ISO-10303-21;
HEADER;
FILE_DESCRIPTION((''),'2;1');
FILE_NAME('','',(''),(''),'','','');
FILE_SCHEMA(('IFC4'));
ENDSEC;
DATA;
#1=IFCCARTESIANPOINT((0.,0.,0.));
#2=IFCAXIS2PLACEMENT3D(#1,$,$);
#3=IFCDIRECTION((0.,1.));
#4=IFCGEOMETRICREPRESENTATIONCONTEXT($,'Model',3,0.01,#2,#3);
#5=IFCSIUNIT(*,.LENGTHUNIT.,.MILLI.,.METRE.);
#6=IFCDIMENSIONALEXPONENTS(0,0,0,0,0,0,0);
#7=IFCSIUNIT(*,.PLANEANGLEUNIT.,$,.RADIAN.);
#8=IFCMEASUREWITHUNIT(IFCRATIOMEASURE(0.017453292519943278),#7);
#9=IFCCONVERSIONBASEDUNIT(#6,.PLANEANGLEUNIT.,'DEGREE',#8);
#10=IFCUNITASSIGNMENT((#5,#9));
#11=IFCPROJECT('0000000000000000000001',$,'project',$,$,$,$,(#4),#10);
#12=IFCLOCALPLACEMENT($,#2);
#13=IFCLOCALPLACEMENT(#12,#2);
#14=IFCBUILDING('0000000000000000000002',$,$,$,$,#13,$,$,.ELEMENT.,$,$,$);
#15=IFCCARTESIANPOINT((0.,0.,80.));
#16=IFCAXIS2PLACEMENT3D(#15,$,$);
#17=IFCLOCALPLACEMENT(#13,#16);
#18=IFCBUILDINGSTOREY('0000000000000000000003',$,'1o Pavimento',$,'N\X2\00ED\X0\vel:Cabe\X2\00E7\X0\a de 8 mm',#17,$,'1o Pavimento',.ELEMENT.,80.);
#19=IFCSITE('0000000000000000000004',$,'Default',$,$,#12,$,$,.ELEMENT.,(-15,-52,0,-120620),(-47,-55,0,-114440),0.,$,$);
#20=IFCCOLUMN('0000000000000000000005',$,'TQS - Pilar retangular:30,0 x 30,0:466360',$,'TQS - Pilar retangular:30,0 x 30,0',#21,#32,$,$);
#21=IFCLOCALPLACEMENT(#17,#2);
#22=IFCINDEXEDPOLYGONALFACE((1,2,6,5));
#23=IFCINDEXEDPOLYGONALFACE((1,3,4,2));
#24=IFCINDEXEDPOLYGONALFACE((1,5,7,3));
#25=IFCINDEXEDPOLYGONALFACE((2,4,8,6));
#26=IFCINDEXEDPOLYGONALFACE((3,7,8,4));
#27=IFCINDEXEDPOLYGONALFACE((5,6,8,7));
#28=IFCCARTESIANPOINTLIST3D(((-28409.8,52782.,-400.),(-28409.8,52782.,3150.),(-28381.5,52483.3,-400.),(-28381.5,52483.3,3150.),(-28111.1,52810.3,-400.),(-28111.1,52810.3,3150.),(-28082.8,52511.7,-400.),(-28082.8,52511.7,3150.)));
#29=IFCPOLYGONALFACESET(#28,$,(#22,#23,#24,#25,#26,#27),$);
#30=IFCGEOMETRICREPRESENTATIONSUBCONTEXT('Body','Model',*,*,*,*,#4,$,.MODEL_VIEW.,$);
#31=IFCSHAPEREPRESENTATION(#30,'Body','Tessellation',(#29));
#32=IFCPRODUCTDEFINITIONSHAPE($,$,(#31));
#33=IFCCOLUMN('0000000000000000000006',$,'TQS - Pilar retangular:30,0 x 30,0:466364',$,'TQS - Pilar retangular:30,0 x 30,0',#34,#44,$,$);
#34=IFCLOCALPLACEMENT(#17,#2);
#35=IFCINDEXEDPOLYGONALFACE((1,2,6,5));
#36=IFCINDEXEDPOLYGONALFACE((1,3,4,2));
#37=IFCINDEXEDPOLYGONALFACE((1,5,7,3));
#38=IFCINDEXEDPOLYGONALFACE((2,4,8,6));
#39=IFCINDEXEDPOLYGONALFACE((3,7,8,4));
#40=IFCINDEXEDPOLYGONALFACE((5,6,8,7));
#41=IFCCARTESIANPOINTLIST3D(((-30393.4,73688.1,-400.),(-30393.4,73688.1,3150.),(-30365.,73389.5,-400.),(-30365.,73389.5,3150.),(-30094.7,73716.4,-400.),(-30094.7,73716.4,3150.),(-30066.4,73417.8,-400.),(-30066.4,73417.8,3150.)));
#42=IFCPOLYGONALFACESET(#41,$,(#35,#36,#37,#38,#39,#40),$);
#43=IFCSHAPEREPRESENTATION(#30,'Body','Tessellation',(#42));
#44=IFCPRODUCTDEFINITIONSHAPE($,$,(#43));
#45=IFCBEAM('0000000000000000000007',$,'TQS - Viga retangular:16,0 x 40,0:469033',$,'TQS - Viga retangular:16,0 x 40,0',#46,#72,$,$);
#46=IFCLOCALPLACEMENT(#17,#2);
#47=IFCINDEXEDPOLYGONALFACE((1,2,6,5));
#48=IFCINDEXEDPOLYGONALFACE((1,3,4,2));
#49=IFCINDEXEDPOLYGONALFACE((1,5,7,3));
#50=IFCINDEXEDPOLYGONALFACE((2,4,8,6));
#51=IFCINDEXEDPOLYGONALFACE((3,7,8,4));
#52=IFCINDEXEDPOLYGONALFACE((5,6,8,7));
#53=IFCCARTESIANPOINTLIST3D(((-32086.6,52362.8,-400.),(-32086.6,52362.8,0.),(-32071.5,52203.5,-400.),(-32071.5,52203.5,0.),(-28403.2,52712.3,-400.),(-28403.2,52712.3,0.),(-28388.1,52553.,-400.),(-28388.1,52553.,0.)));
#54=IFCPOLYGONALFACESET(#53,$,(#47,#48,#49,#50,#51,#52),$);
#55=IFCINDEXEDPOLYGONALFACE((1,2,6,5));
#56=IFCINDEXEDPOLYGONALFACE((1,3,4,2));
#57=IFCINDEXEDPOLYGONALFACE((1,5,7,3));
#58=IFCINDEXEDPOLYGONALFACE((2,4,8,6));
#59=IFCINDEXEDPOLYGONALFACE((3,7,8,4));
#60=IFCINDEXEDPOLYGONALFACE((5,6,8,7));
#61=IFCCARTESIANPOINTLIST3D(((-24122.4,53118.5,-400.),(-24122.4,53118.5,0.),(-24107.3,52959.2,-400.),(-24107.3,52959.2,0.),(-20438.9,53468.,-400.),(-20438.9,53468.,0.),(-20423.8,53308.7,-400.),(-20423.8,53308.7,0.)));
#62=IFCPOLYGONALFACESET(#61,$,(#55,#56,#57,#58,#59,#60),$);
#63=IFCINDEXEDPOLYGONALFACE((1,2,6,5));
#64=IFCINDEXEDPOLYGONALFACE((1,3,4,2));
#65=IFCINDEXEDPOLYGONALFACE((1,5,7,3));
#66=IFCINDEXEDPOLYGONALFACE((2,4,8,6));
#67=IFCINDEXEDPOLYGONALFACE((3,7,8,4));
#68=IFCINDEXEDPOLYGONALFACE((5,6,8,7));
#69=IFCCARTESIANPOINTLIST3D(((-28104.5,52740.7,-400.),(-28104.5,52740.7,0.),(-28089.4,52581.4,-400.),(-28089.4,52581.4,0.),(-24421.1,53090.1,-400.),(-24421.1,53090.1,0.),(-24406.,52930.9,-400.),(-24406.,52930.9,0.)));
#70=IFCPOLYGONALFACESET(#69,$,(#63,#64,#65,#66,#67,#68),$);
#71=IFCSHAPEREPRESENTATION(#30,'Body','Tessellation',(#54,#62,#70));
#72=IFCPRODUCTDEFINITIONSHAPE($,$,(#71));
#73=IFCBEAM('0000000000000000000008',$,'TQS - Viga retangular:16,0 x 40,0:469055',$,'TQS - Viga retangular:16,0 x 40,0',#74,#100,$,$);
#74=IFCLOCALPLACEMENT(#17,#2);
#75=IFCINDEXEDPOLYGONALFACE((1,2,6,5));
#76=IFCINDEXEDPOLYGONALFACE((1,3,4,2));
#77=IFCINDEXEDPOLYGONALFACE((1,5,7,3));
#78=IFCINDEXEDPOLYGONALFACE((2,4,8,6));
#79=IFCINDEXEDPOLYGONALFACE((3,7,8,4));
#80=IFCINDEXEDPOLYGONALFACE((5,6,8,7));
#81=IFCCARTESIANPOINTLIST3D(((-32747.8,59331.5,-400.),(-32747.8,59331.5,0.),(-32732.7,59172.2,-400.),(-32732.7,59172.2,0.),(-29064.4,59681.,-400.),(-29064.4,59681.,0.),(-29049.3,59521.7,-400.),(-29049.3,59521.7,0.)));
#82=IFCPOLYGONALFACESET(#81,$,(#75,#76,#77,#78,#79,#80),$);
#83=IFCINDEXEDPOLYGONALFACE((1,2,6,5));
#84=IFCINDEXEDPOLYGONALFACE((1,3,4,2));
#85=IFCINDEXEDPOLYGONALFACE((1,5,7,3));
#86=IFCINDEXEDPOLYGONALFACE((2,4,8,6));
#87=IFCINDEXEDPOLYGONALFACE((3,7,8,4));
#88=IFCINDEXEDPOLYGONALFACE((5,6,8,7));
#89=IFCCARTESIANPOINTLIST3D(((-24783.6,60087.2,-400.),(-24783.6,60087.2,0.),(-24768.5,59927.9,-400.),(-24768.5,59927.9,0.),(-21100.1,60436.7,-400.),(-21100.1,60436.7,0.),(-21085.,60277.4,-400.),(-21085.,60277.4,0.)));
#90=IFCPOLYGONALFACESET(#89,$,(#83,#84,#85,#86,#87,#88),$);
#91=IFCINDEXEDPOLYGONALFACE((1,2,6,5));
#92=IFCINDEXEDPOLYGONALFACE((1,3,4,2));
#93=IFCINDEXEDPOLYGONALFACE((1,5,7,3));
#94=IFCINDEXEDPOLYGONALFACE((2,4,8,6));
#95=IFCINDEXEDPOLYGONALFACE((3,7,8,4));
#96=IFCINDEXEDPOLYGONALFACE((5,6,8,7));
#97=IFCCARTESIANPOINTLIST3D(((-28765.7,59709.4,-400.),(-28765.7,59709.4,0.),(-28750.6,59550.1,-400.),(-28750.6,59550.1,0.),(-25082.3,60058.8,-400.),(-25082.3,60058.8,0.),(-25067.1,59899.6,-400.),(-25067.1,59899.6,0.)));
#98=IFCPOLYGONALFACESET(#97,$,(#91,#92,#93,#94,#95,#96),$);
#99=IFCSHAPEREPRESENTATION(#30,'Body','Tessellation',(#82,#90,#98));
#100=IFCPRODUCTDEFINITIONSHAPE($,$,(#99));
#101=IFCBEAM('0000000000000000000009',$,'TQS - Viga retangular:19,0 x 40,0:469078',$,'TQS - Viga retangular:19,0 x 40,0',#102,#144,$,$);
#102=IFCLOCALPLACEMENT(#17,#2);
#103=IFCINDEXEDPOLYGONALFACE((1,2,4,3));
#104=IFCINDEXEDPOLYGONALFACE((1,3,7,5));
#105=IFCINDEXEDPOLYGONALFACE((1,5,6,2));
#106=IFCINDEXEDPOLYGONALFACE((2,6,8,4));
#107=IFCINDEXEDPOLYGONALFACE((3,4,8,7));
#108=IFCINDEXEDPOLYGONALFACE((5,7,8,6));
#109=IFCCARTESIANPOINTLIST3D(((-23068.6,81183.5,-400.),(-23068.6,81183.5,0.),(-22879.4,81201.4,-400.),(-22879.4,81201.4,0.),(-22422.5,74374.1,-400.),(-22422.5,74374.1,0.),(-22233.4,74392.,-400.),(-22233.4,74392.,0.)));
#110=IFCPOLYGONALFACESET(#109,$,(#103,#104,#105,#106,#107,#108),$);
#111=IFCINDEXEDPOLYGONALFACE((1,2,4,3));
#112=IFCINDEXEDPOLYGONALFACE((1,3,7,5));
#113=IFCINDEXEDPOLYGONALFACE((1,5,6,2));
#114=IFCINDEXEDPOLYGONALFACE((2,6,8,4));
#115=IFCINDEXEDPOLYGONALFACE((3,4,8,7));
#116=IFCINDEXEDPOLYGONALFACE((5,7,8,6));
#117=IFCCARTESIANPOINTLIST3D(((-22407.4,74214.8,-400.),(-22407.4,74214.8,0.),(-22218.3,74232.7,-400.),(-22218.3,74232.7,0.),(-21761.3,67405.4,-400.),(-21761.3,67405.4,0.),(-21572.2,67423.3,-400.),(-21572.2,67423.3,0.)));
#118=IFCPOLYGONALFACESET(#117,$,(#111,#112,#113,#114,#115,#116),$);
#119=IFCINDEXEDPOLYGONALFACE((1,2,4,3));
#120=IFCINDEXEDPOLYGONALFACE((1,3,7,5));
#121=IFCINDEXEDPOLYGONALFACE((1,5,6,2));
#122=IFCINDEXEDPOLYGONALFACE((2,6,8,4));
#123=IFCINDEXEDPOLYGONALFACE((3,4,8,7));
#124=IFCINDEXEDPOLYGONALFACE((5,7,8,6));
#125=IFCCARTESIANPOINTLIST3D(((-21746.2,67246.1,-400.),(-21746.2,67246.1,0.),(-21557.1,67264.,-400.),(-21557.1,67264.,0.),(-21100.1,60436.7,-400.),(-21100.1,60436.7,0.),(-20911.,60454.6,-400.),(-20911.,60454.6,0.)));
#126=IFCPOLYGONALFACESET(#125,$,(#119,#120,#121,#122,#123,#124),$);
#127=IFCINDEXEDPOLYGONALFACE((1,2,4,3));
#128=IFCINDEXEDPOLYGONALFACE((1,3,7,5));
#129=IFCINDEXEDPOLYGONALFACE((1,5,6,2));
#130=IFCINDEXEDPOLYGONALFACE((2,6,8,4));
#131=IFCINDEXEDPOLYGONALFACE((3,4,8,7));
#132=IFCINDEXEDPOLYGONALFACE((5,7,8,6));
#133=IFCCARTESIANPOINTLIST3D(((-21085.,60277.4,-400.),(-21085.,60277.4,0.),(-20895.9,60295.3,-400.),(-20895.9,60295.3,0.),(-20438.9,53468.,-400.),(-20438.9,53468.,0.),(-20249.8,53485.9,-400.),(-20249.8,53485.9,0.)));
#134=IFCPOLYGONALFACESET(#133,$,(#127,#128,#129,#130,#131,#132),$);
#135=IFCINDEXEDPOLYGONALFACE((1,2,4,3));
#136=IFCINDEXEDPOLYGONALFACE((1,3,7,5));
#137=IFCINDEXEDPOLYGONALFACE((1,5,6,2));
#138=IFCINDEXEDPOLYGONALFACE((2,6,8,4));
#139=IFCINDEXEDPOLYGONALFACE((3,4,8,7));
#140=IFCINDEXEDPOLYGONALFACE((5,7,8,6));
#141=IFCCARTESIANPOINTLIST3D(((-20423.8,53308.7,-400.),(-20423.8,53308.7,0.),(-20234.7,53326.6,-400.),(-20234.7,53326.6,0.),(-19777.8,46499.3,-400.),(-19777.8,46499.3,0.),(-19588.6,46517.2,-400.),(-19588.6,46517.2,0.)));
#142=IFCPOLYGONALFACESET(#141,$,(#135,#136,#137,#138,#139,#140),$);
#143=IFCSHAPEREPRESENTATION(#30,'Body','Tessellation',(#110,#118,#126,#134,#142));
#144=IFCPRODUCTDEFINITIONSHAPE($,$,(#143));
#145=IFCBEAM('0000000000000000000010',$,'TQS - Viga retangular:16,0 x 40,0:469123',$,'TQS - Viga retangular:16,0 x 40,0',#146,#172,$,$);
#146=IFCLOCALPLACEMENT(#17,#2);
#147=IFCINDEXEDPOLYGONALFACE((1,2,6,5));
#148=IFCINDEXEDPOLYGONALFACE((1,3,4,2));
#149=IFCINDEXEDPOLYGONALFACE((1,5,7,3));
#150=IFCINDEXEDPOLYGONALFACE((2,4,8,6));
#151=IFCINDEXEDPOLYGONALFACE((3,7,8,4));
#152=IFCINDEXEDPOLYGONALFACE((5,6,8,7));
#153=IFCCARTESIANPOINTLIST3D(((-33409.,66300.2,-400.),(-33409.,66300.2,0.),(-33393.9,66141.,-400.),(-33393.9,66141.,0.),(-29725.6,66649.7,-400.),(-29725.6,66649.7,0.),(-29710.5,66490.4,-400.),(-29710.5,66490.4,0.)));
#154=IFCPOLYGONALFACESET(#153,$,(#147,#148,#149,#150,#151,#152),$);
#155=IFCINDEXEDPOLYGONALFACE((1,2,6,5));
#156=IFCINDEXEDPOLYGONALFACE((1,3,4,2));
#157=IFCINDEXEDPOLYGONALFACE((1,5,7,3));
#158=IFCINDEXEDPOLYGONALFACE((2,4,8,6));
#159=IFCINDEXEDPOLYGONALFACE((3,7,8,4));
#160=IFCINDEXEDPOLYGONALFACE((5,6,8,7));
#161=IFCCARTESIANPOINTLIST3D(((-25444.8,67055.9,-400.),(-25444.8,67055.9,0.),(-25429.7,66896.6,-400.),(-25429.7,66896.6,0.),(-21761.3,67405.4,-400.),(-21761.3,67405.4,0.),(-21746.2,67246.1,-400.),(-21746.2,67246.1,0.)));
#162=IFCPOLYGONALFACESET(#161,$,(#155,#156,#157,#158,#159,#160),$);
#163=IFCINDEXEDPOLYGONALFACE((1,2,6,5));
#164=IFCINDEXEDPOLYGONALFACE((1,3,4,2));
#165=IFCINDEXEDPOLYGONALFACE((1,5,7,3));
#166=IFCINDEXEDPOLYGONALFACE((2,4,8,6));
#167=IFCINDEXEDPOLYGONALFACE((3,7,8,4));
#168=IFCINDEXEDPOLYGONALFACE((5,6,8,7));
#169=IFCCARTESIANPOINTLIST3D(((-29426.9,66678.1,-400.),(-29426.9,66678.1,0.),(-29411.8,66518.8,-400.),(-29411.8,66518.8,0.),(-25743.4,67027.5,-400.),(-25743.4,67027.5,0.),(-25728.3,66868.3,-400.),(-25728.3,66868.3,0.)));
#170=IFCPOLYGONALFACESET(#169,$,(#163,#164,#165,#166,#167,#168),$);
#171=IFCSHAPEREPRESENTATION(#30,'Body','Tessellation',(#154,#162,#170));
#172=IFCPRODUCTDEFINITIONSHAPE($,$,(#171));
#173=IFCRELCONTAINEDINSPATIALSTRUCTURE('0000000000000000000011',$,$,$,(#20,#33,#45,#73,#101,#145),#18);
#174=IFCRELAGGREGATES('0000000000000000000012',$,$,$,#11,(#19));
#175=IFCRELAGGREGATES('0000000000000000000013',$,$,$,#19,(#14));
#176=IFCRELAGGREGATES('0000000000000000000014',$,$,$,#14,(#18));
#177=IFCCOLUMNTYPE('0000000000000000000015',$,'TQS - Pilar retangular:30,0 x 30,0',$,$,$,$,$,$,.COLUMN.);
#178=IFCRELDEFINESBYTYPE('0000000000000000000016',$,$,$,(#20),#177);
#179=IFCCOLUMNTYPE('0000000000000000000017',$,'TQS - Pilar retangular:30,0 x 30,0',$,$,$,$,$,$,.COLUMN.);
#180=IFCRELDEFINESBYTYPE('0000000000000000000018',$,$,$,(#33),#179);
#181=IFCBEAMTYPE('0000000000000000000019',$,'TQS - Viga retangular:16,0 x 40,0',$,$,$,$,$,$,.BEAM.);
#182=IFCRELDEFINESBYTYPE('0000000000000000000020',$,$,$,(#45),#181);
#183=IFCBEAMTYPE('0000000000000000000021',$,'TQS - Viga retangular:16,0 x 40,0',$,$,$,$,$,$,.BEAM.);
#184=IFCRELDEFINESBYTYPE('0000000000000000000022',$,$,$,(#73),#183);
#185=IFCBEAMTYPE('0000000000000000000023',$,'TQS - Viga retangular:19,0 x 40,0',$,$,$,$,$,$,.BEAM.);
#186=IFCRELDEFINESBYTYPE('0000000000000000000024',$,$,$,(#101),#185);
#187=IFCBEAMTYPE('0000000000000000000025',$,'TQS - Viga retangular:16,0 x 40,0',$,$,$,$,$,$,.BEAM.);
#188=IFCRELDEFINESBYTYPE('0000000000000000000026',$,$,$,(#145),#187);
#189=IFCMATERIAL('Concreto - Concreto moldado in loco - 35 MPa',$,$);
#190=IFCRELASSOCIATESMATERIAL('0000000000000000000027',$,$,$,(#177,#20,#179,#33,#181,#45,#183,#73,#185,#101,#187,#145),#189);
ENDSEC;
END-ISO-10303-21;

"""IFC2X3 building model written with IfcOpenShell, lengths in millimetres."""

from ifc_helpers import new_model, entity, si_unit, converted_unit, direction, frame, frame_2d, origin, origin_2d_with_axis, place, context, subcontext, project, spatial, rectangle, extrude, source, transform, mapped, material, type_object, type_shapes, element, save


model = new_model("IFC2X3")

# Units and contexts
model_context = context("Model", 3, precision=0.01, world=origin(), true_north=direction((0.0, 1.0)))
body_context = subcontext(model_context, "Body", "Model", "MODEL_VIEW")
ifc_project = project(units=[si_unit("LENGTHUNIT", "METRE", prefix="MILLI"), converted_unit("PLANEANGLEUNIT", "DEGREE", entity("IfcRatioMeasure", 0.017453292519943278), si_unit("PLANEANGLEUNIT", "RADIAN"), dimensions=[0, 0, 0, 0, 0, 0, 0])], contexts=[model_context])

# Site, building, storey
site_placement = place(None, origin())
site = spatial("IfcSite", under=ifc_project, at=site_placement, Name="Default", CompositionType="ELEMENT", RefLatitude=(-15, -52, 0, -120620), RefLongitude=(-47, -55, 0, -114440), RefElevation=0.0)
building_placement = place(site_placement, origin())
building = spatial("IfcBuilding", under=site, at=building_placement, CompositionType="ELEMENT")
storey_placement = place(building_placement, frame((0.0, 0.0, 80.0)))
storey = spatial("IfcBuildingStorey", under=building, at=storey_placement, Name="1o Pavimento", ObjectType="Nível:Cabeça de 8 mm", LongName="1o Pavimento", CompositionType="ELEMENT", Elevation=80.0)

# Columns
ifc_material = material(Name="Concreto - Concreto moldado in loco - 35 MPa")
column_type_1 = type_object("IfcColumnType", Name="TQS - Pilar retangular:30,0 x 30,0", PredefinedType="COLUMN", material=ifc_material)
shared_shape_1 = source(origin(), body_context, "Body", "SweptSolid", [
    extrude(rectangle(XDim=300.0, YDim=300.0, at=origin_2d_with_axis()), frame((-28246.3, 52646.8, -320.0), z_axis=(0.0, 0.0, 1.0), x_axis=(-0.995529, -0.094456, 0.0)), (0.0, 0.0, 1.0), 3550.0),
])
type_shapes(column_type_1, [shared_shape_1])
column_1_placement = place(storey_placement, frame((0.0, 0.0, -80.0)))
element("IfcColumn", 1, at=column_1_placement, inside=storey, type_object=column_type_1, material=ifc_material, Name="TQS - Pilar retangular:30,0 x 30,0:466360", ObjectType="TQS - Pilar retangular:30,0 x 30,0", context=body_context, shape_type="MappedRepresentation", body=[
    mapped(shared_shape_1, transform((0.0, 0.0, 0.0), scale=1.0)),
])
column_type_2 = type_object("IfcColumnType", Name="TQS - Pilar retangular:30,0 x 30,0", PredefinedType="COLUMN", material=ifc_material)
shared_shape_2 = source(origin(), body_context, "Body", "SweptSolid", [
    extrude(rectangle(XDim=300.0, YDim=300.0, at=origin_2d_with_axis()), frame((-30229.9, 73553.0, -320.0), z_axis=(0.0, 0.0, 1.0), x_axis=(-0.995529, -0.094456, 0.0)), (0.0, 0.0, 1.0), 3550.0),
])
type_shapes(column_type_2, [shared_shape_2])
column_2_placement = place(storey_placement, frame((0.0, 0.0, -80.0)))
element("IfcColumn", 2, at=column_2_placement, inside=storey, type_object=column_type_2, material=ifc_material, Name="TQS - Pilar retangular:30,0 x 30,0:466364", ObjectType="TQS - Pilar retangular:30,0 x 30,0", context=body_context, shape_type="MappedRepresentation", body=[
    mapped(shared_shape_2, transform((0.0, 0.0, 0.0), scale=1.0)),
])

# Beams
beam_type_1 = type_object("IfcBeamType", Name="TQS - Viga retangular:16,0 x 40,0", PredefinedType="BEAM", material=ifc_material)
shared_shape_3 = source(origin(), body_context, "Body", "SweptSolid", [
    extrude(rectangle(XDim=400.0, YDim=160.0, at=frame_2d((0.0, 0.0), x_axis=(1.0, 0.0))), frame((-28395.6, 52632.7, -120.0), z_axis=(-0.995529, -0.094456, 0.0), x_axis=(0.0, 0.0, -1.0)), (0.0, 0.0, 1.0), 3700.0),
    extrude(rectangle(XDim=400.0, YDim=160.0, at=frame_2d((0.0, 0.0), x_axis=(1.0, 0.0))), frame((-20431.4, 53388.3, -120.0), z_axis=(-0.995529, -0.094456, 0.0), x_axis=(0.0, 0.0, -1.0)), (0.0, 0.0, 1.0), 3700.0),
    extrude(rectangle(XDim=400.0, YDim=160.0, at=frame_2d((0.0, 0.0), x_axis=(1.0, 0.0))), frame((-24413.5, 53010.5, -120.0), z_axis=(-0.995529, -0.094456, 0.0), x_axis=(0.0, 0.0, -1.0)), (0.0, 0.0, 1.0), 3700.0),
])
type_shapes(beam_type_1, [shared_shape_3])
beam_1_placement = place(storey_placement, frame((0.0, 0.0, -80.0)))
element("IfcBeam", 3, at=beam_1_placement, inside=storey, type_object=beam_type_1, material=ifc_material, Name="TQS - Viga retangular:16,0 x 40,0:469033", ObjectType="TQS - Viga retangular:16,0 x 40,0", context=body_context, shape_type="MappedRepresentation", body=[
    mapped(shared_shape_3, transform((0.0, 0.0, 0.0), scale=1.0)),
])
beam_type_2 = type_object("IfcBeamType", Name="TQS - Viga retangular:16,0 x 40,0", PredefinedType="BEAM", material=ifc_material)
shared_shape_4 = source(origin(), body_context, "Body", "SweptSolid", [
    extrude(rectangle(XDim=400.0, YDim=160.0, at=origin_2d_with_axis()), frame((-29056.8, 59601.4, -120.0), z_axis=(-0.995529, -0.094456, 0.0), x_axis=(0.0, 0.0, -1.0)), (0.0, 0.0, 1.0), 3700.0),
    extrude(rectangle(XDim=400.0, YDim=160.0, at=frame_2d((0.0, 0.0), x_axis=(1.0, 0.0))), frame((-21092.6, 60357.0, -120.0), z_axis=(-0.995529, -0.094456, 0.0), x_axis=(0.0, 0.0, -1.0)), (0.0, 0.0, 1.0), 3700.0),
    extrude(rectangle(XDim=400.0, YDim=160.0, at=frame_2d((0.0, 0.0), x_axis=(1.0, 0.0))), frame((-25074.7, 59979.2, -120.0), z_axis=(-0.995529, -0.094456, 0.0), x_axis=(0.0, 0.0, -1.0)), (0.0, 0.0, 1.0), 3700.0),
])
type_shapes(beam_type_2, [shared_shape_4])
beam_2_placement = place(storey_placement, frame((0.0, 0.0, -80.0)))
element("IfcBeam", 4, at=beam_2_placement, inside=storey, type_object=beam_type_2, material=ifc_material, Name="TQS - Viga retangular:16,0 x 40,0:469055", ObjectType="TQS - Viga retangular:16,0 x 40,0", context=body_context, shape_type="MappedRepresentation", body=[
    mapped(shared_shape_4, transform((0.0, 0.0, 0.0), scale=1.0)),
])
beam_type_3 = type_object("IfcBeamType", Name="TQS - Viga retangular:19,0 x 40,0", PredefinedType="BEAM", material=ifc_material)
shared_shape_5 = source(origin(), body_context, "Body", "SweptSolid", [
    extrude(rectangle(XDim=400.0, YDim=190.0, at=frame_2d((0.0, 0.0), x_axis=(1.0, 0.0))), frame((-22327.9, 74383.0, -120.0), z_axis=(-0.094456, 0.995529, 0.0), x_axis=(0.0, 0.0, 1.0)), (0.0, 0.0, 1.0), 6840.0),
    extrude(rectangle(XDim=400.0, YDim=190.0, at=frame_2d((0.0, 0.0), x_axis=(1.0, 0.0))), frame((-21666.8, 67414.3, -120.0), z_axis=(-0.094456, 0.995529, 0.0), x_axis=(0.0, 0.0, 1.0)), (0.0, 0.0, 1.0), 6840.0),
    extrude(rectangle(XDim=400.0, YDim=190.0, at=frame_2d((0.0, 0.0), x_axis=(1.0, 0.0))), frame((-21005.6, 60445.6, -120.0), z_axis=(-0.094456, 0.995529, 0.0), x_axis=(0.0, 0.0, 1.0)), (0.0, 0.0, 1.0), 6840.0),
    extrude(rectangle(XDim=400.0, YDim=190.0, at=frame_2d((0.0, 0.0), x_axis=(1.0, 0.0))), frame((-20344.4, 53476.9, -120.0), z_axis=(-0.094456, 0.995529, 0.0), x_axis=(0.0, 0.0, 1.0)), (0.0, 0.0, 1.0), 6840.0),
    extrude(rectangle(XDim=400.0, YDim=190.0, at=frame_2d((0.0, 0.0), x_axis=(1.0, 0.0))), frame((-19683.2, 46508.2, -120.0), z_axis=(-0.094456, 0.995529, 0.0), x_axis=(0.0, 0.0, 1.0)), (0.0, 0.0, 1.0), 6840.0),
])
type_shapes(beam_type_3, [shared_shape_5])
beam_3_placement = place(storey_placement, frame((0.0, 0.0, -80.0)))
element("IfcBeam", 5, at=beam_3_placement, inside=storey, type_object=beam_type_3, material=ifc_material, Name="TQS - Viga retangular:19,0 x 40,0:469078", ObjectType="TQS - Viga retangular:19,0 x 40,0", context=body_context, shape_type="MappedRepresentation", body=[
    mapped(shared_shape_5, transform((0.0, 0.0, 0.0), scale=1.0)),
])
beam_type_4 = type_object("IfcBeamType", Name="TQS - Viga retangular:16,0 x 40,0", PredefinedType="BEAM", material=ifc_material)
shared_shape_6 = source(origin(), body_context, "Body", "SweptSolid", [
    extrude(rectangle(XDim=400.0, YDim=160.0, at=origin_2d_with_axis()), frame((-29718.0, 66570.1, -120.0), z_axis=(-0.995529, -0.094456, 0.0), x_axis=(0.0, 0.0, -1.0)), (0.0, 0.0, 1.0), 3700.0),
    extrude(rectangle(XDim=400.0, YDim=160.0, at=frame_2d((0.0, 0.0), x_axis=(1.0, 0.0))), frame((-21753.8, 67325.7, -120.0), z_axis=(-0.995529, -0.094456, 0.0), x_axis=(0.0, 0.0, -1.0)), (0.0, 0.0, 1.0), 3700.0),
    extrude(rectangle(XDim=400.0, YDim=160.0, at=frame_2d((0.0, 0.0), x_axis=(1.0, 0.0))), frame((-25735.9, 66947.9, -120.0), z_axis=(-0.995529, -0.094456, 0.0), x_axis=(0.0, 0.0, -1.0)), (0.0, 0.0, 1.0), 3700.0),
])
type_shapes(beam_type_4, [shared_shape_6])
beam_4_placement = place(storey_placement, frame((0.0, 0.0, -80.0)))
element("IfcBeam", 6, at=beam_4_placement, inside=storey, type_object=beam_type_4, material=ifc_material, Name="TQS - Viga retangular:16,0 x 40,0:469123", ObjectType="TQS - Viga retangular:16,0 x 40,0", context=body_context, shape_type="MappedRepresentation", body=[
    mapped(shared_shape_6, transform((0.0, 0.0, 0.0), scale=1.0)),
])

save(model, "model.ifc")
